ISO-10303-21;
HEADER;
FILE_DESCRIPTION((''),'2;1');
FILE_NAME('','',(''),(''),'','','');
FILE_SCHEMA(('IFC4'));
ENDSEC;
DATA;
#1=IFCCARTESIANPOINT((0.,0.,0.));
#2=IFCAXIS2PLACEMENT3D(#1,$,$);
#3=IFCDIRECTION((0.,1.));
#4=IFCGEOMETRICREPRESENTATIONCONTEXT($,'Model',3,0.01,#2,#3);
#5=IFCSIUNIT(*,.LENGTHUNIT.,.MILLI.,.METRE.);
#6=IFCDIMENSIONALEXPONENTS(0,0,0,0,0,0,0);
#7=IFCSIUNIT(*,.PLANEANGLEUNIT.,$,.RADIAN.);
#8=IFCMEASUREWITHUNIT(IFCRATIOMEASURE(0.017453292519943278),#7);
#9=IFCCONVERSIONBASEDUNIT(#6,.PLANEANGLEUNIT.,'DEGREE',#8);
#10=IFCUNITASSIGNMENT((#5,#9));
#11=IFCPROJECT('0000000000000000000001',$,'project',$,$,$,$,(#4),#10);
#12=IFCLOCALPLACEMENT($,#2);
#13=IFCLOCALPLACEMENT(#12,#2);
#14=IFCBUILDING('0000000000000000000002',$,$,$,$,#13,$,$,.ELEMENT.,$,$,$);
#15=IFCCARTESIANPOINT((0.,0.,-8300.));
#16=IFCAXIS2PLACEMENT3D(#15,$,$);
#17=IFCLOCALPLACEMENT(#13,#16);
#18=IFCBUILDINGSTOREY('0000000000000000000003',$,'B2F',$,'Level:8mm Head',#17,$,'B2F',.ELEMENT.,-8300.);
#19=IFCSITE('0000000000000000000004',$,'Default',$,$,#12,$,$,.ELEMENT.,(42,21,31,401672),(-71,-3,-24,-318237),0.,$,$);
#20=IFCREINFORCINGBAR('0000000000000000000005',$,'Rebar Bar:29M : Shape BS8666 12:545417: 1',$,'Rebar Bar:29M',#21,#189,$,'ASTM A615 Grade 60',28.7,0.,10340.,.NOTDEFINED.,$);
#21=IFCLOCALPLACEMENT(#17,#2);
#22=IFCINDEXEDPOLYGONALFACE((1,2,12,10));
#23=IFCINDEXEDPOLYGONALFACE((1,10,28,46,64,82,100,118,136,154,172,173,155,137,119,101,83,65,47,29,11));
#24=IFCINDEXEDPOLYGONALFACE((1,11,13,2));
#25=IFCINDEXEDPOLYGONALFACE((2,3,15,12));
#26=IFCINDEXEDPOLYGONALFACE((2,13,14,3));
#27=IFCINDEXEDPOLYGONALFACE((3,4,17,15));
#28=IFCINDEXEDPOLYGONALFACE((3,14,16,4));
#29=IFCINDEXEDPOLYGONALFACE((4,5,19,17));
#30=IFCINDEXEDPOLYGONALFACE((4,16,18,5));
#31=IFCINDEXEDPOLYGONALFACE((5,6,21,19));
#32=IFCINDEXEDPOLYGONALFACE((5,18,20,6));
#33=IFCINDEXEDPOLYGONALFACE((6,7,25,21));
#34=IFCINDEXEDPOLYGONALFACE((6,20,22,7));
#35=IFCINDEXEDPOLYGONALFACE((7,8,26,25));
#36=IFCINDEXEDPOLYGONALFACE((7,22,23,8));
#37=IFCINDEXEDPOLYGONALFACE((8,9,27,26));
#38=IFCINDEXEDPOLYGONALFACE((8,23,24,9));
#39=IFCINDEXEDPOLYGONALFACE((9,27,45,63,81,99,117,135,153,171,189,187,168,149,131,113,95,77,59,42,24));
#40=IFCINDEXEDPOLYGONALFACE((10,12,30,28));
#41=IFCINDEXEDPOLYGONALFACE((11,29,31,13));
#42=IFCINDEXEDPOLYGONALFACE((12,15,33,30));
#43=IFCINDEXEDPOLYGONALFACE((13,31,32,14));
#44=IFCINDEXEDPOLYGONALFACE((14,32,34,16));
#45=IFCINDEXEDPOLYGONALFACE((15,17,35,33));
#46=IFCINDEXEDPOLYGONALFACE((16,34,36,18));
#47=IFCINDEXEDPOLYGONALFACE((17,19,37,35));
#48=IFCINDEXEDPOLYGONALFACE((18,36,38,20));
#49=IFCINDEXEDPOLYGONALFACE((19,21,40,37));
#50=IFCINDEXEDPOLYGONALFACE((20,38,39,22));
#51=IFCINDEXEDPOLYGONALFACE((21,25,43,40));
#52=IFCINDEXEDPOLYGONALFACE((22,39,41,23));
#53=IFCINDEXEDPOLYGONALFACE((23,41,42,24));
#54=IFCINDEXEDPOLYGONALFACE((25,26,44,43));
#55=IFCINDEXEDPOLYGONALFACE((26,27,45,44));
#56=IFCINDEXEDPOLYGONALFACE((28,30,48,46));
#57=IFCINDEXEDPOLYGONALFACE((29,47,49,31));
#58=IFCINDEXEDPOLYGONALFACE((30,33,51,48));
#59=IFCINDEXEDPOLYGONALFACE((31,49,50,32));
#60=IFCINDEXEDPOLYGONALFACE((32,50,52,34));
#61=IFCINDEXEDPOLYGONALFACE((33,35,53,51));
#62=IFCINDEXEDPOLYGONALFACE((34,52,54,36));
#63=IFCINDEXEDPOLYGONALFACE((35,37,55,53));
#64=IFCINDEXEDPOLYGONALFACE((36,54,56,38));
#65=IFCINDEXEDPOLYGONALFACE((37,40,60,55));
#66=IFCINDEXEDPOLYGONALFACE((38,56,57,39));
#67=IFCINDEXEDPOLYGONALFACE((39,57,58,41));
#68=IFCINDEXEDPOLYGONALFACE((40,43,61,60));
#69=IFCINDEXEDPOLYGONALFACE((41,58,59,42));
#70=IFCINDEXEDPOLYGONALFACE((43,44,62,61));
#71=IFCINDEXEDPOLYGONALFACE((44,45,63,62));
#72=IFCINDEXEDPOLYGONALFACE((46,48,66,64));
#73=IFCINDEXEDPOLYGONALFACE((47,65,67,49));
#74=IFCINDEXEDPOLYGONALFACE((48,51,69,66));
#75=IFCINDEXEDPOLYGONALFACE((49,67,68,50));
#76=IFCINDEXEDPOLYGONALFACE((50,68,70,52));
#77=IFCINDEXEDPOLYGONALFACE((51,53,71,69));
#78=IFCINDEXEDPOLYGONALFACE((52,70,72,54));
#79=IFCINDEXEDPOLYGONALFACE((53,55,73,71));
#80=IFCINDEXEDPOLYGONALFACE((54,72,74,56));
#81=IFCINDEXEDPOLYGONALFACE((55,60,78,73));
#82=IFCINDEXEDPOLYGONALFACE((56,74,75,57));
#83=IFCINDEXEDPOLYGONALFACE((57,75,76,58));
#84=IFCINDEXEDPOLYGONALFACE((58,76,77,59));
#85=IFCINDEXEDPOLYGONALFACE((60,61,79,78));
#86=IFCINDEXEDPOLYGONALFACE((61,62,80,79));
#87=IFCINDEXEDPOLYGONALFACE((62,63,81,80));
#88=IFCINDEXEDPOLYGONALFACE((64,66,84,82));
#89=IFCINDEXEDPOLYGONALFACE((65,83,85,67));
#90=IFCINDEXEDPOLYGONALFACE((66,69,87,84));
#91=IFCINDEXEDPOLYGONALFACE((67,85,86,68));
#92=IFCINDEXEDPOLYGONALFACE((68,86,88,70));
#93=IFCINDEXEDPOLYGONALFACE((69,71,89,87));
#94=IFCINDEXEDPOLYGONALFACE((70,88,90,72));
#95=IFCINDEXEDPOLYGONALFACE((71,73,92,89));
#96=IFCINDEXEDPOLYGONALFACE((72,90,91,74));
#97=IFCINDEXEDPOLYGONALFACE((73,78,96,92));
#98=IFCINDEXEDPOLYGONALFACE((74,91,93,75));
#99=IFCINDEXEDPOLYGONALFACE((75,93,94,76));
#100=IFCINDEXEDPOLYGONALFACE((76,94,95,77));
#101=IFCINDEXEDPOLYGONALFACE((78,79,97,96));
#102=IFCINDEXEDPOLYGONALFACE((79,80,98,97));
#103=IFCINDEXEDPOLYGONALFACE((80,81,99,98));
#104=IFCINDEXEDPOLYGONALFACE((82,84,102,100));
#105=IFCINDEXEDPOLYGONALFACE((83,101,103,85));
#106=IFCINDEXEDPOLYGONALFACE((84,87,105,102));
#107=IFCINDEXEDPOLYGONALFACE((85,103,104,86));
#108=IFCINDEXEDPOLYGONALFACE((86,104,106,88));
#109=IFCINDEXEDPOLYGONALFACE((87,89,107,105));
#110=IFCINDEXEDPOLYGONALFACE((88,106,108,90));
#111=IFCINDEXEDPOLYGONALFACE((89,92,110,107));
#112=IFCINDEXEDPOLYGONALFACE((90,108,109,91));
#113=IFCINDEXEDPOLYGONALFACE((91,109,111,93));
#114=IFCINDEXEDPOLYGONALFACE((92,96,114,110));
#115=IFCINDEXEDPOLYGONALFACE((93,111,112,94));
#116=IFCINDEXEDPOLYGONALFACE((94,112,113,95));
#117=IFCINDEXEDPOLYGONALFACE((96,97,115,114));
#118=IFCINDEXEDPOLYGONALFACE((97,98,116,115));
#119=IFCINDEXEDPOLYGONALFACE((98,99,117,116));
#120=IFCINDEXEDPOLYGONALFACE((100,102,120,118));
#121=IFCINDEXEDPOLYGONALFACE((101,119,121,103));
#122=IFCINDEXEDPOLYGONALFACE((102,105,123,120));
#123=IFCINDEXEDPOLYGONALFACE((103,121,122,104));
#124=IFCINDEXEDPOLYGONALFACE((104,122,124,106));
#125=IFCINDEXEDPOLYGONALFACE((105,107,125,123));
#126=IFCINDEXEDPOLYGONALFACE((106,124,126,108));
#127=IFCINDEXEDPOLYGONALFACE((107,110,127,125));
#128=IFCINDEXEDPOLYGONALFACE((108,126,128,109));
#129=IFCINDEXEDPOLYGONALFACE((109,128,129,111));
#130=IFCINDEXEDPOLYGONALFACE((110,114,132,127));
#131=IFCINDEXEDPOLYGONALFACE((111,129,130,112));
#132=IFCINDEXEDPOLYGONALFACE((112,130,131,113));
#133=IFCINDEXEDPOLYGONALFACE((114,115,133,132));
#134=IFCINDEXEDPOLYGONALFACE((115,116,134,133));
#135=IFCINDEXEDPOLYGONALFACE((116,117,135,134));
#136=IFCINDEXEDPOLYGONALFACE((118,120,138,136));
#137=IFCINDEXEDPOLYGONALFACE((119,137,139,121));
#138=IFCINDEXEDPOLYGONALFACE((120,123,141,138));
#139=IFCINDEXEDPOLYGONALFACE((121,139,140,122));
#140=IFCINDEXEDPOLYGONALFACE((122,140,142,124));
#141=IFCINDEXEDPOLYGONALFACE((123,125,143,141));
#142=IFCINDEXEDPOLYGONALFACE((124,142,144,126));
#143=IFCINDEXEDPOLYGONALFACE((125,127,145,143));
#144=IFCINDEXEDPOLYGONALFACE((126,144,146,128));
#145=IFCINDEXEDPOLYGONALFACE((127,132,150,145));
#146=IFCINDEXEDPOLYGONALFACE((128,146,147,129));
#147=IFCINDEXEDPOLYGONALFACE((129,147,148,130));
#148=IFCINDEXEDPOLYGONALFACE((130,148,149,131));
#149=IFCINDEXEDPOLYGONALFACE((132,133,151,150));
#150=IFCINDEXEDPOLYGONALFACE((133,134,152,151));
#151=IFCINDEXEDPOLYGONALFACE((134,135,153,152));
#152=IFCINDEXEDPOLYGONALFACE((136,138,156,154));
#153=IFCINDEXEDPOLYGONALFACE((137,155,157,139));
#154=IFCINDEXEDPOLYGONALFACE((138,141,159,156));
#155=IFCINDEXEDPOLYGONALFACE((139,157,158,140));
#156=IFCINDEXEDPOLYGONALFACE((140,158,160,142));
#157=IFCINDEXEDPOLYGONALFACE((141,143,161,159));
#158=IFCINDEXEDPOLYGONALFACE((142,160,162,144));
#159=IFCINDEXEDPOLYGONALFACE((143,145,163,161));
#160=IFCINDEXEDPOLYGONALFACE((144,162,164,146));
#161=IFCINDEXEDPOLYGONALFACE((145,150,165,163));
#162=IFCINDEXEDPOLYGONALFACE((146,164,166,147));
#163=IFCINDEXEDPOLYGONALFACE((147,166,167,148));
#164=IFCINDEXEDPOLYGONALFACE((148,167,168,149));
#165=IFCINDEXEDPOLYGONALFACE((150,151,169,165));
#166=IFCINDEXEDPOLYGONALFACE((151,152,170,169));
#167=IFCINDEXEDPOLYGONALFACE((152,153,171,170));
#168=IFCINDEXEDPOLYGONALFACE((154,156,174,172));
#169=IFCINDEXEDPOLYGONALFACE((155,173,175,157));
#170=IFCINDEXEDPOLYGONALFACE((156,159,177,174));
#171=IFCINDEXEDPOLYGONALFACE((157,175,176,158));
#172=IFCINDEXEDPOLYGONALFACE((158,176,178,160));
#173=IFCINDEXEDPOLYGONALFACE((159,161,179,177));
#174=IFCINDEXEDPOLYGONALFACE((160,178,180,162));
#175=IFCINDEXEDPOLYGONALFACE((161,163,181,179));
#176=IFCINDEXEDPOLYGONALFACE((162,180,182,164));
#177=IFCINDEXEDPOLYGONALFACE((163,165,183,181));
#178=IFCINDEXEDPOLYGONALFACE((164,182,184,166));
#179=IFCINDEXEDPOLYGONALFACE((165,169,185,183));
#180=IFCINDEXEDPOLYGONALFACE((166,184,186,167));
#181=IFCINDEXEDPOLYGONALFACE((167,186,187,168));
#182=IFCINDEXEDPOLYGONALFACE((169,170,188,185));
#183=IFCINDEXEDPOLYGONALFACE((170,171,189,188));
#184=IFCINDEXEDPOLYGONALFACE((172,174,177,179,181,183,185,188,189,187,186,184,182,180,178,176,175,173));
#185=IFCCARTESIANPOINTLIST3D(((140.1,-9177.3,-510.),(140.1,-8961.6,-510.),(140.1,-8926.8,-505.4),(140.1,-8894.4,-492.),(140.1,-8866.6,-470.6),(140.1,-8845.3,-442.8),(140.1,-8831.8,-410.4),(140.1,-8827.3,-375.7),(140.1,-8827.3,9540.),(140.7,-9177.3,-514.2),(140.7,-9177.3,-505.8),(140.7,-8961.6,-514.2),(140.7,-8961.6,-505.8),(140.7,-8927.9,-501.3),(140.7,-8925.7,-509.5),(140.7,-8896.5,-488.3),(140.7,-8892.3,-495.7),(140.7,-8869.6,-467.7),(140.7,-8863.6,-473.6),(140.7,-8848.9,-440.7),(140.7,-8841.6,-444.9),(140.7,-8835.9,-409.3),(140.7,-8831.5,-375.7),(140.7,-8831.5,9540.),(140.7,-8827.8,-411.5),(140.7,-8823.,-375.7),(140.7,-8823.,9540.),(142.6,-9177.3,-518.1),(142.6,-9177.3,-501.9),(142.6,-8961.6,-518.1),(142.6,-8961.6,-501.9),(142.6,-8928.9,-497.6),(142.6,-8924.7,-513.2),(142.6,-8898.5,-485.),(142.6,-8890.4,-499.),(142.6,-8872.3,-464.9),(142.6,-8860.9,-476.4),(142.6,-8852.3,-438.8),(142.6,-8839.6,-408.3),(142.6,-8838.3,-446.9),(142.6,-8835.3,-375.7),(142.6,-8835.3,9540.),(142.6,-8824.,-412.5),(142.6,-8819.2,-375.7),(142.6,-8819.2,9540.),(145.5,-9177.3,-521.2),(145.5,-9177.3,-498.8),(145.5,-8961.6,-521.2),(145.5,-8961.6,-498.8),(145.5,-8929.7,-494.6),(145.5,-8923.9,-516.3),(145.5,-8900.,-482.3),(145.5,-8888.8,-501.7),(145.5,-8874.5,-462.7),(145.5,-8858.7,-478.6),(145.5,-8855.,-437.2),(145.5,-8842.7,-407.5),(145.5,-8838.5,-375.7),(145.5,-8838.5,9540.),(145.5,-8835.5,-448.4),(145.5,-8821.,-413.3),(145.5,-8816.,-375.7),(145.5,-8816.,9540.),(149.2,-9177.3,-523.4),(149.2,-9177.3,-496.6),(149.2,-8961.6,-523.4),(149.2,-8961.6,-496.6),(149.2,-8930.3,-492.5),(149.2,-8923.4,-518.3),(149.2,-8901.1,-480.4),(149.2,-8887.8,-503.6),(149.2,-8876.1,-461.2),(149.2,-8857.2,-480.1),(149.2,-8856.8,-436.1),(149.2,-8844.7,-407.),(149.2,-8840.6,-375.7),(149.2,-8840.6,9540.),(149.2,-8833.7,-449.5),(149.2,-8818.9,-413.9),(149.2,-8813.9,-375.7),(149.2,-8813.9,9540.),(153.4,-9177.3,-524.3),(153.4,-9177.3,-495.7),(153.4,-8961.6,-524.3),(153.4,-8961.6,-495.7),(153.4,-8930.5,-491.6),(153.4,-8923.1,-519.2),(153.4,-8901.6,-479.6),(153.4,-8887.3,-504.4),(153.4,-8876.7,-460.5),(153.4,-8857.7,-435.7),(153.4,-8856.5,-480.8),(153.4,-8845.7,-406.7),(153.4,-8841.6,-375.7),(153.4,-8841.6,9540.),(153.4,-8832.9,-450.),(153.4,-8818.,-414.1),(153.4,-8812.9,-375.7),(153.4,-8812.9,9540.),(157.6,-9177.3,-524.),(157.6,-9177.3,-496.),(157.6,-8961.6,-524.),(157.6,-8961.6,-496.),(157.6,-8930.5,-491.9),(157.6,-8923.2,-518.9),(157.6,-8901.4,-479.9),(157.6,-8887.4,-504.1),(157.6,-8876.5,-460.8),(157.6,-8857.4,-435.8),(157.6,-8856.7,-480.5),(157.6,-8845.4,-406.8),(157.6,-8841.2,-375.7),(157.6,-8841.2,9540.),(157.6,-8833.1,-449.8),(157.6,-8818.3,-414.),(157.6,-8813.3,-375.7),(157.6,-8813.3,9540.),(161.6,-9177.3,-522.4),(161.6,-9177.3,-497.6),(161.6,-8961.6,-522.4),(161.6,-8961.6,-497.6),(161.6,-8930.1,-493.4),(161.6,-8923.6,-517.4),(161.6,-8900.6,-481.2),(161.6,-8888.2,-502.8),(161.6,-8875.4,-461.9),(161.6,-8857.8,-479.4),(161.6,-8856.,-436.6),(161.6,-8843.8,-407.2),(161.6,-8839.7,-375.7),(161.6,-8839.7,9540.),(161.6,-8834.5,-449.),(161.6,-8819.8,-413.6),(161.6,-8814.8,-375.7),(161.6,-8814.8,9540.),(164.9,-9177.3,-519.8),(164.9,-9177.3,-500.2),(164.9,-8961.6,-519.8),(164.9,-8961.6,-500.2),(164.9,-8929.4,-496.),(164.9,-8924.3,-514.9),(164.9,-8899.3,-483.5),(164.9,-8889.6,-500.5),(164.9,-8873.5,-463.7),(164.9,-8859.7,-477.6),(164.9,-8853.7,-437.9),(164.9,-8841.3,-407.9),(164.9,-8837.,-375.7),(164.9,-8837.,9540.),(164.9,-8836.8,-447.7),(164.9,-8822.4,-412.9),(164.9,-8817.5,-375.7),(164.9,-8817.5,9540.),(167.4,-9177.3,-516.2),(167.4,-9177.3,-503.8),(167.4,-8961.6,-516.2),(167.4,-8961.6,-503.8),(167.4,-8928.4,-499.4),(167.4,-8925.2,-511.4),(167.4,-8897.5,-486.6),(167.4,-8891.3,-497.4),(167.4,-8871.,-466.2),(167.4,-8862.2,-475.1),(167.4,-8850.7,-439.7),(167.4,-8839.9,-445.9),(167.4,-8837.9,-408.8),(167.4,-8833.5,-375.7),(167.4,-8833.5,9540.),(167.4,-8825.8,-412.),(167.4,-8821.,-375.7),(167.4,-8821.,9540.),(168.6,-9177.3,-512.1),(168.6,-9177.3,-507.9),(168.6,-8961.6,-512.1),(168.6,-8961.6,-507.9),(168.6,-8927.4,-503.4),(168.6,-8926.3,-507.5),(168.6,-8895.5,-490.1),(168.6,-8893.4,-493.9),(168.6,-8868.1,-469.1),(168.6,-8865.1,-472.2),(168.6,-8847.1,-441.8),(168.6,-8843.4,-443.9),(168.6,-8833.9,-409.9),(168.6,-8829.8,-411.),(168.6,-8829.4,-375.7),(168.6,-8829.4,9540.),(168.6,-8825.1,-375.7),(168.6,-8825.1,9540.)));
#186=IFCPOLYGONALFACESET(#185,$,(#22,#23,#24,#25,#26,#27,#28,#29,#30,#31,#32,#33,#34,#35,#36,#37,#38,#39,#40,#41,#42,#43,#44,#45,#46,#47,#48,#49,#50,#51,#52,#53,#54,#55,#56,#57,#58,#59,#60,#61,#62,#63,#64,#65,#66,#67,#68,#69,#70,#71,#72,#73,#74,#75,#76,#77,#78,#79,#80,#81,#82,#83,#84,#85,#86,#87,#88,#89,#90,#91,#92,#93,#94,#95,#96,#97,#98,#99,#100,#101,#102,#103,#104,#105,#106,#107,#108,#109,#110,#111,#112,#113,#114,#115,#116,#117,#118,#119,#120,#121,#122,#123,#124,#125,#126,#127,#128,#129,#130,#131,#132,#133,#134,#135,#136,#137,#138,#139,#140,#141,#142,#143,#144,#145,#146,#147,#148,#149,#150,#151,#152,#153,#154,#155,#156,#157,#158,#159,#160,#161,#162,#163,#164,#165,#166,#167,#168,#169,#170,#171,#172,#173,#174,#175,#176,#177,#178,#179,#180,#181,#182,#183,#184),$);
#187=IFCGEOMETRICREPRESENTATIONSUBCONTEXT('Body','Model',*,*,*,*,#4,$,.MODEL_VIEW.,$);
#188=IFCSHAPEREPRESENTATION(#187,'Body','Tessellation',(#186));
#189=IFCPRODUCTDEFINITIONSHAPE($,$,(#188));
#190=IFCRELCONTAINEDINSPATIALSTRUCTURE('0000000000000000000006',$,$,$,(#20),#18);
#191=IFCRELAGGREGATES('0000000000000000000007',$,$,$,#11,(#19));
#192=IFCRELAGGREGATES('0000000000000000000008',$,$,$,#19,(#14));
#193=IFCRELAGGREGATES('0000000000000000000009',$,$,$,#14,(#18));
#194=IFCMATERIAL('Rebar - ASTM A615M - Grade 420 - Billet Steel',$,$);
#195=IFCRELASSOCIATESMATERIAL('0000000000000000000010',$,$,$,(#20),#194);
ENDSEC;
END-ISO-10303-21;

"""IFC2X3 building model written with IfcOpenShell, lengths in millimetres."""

from ifc_helpers import new_model, entity, si_unit, converted_unit, direction, frame, origin, place, context, subcontext, project, spatial, material, element, save


model = new_model("IFC2X3")

# Units and contexts
model_context = context("Model", 3, precision=0.01, world=origin(), true_north=direction((0.0, 1.0)))
body_context = subcontext(model_context, "Body", "Model", "MODEL_VIEW")
ifc_project = project(units=[si_unit("LENGTHUNIT", "METRE", prefix="MILLI"), converted_unit("PLANEANGLEUNIT", "DEGREE", entity("IfcRatioMeasure", 0.017453292519943278), si_unit("PLANEANGLEUNIT", "RADIAN"), dimensions=[0, 0, 0, 0, 0, 0, 0])], contexts=[model_context])

# Site, building, storey
site_placement = place(None, origin())
site = spatial("IfcSite", under=ifc_project, at=site_placement, Name="Default", CompositionType="ELEMENT", RefLatitude=(42, 21, 31, 401672), RefLongitude=(-71, -3, -24, -318237), RefElevation=0.0)
building_placement = place(site_placement, origin())
building = spatial("IfcBuilding", under=site, at=building_placement, CompositionType="ELEMENT")
storey_placement = place(building_placement, frame((0.0, 0.0, -8300.0)))
storey = spatial("IfcBuildingStorey", under=building, at=storey_placement, Name="B2F", ObjectType="Level:8mm Head", LongName="B2F", CompositionType="ELEMENT", Elevation=-8300.0)

# Reinforcing bar
ifc_material_1 = material(Name="Rebar - ASTM A615M - Grade 420 - Billet Steel")
reinforcing_bar_1_placement = place(storey_placement, origin())
element("IfcReinforcingBar", 1, at=reinforcing_bar_1_placement, inside=storey, material=ifc_material_1, Name="Rebar Bar:29M : Shape BS8666 12:545417: 1", SteelGrade="ASTM A615 Grade 60", ObjectType="Rebar Bar:29M", BarLength=10340.0, BarRole="NOTDEFINED", CrossSectionArea=0.0, NominalDiameter=28.7, context=body_context, shape_type="AdvancedSweptSolid", body=[
    entity("IfcSweptDiskSolid", entity("IfcCompositeCurve", [entity("IfcCompositeCurveSegment", "CONTINUOUS", True, entity("IfcPolyline", [entity("IfcCartesianPoint", [154.4, -8827.3, 9540.0]), entity("IfcCartesianPoint", [154.4, -8827.3, -375.7])])), entity("IfcCompositeCurveSegment", "CONTINUOUS", True, entity("IfcTrimmedCurve", entity("IfcCircle", entity("IfcAxis2Placement3D", entity("IfcCartesianPoint", [154.4, -8961.6, -375.7]), entity("IfcDirection", [-1.0, 0.0, 0.0]), entity("IfcDirection", [0.0, 0.0, -1.0])), 134.3), [entity("IfcParameterValue", 270.0)], [entity("IfcParameterValue", 360.0)], True, "PARAMETER")), entity("IfcCompositeCurveSegment", "CONTINUOUS", True, entity("IfcPolyline", [entity("IfcCartesianPoint", [154.4, -8961.6, -510.0]), entity("IfcCartesianPoint", [154.4, -9177.3, -510.0])]))], False), 14.3, None, 0.0, 92.0),
])

save(model, "model.ifc")
